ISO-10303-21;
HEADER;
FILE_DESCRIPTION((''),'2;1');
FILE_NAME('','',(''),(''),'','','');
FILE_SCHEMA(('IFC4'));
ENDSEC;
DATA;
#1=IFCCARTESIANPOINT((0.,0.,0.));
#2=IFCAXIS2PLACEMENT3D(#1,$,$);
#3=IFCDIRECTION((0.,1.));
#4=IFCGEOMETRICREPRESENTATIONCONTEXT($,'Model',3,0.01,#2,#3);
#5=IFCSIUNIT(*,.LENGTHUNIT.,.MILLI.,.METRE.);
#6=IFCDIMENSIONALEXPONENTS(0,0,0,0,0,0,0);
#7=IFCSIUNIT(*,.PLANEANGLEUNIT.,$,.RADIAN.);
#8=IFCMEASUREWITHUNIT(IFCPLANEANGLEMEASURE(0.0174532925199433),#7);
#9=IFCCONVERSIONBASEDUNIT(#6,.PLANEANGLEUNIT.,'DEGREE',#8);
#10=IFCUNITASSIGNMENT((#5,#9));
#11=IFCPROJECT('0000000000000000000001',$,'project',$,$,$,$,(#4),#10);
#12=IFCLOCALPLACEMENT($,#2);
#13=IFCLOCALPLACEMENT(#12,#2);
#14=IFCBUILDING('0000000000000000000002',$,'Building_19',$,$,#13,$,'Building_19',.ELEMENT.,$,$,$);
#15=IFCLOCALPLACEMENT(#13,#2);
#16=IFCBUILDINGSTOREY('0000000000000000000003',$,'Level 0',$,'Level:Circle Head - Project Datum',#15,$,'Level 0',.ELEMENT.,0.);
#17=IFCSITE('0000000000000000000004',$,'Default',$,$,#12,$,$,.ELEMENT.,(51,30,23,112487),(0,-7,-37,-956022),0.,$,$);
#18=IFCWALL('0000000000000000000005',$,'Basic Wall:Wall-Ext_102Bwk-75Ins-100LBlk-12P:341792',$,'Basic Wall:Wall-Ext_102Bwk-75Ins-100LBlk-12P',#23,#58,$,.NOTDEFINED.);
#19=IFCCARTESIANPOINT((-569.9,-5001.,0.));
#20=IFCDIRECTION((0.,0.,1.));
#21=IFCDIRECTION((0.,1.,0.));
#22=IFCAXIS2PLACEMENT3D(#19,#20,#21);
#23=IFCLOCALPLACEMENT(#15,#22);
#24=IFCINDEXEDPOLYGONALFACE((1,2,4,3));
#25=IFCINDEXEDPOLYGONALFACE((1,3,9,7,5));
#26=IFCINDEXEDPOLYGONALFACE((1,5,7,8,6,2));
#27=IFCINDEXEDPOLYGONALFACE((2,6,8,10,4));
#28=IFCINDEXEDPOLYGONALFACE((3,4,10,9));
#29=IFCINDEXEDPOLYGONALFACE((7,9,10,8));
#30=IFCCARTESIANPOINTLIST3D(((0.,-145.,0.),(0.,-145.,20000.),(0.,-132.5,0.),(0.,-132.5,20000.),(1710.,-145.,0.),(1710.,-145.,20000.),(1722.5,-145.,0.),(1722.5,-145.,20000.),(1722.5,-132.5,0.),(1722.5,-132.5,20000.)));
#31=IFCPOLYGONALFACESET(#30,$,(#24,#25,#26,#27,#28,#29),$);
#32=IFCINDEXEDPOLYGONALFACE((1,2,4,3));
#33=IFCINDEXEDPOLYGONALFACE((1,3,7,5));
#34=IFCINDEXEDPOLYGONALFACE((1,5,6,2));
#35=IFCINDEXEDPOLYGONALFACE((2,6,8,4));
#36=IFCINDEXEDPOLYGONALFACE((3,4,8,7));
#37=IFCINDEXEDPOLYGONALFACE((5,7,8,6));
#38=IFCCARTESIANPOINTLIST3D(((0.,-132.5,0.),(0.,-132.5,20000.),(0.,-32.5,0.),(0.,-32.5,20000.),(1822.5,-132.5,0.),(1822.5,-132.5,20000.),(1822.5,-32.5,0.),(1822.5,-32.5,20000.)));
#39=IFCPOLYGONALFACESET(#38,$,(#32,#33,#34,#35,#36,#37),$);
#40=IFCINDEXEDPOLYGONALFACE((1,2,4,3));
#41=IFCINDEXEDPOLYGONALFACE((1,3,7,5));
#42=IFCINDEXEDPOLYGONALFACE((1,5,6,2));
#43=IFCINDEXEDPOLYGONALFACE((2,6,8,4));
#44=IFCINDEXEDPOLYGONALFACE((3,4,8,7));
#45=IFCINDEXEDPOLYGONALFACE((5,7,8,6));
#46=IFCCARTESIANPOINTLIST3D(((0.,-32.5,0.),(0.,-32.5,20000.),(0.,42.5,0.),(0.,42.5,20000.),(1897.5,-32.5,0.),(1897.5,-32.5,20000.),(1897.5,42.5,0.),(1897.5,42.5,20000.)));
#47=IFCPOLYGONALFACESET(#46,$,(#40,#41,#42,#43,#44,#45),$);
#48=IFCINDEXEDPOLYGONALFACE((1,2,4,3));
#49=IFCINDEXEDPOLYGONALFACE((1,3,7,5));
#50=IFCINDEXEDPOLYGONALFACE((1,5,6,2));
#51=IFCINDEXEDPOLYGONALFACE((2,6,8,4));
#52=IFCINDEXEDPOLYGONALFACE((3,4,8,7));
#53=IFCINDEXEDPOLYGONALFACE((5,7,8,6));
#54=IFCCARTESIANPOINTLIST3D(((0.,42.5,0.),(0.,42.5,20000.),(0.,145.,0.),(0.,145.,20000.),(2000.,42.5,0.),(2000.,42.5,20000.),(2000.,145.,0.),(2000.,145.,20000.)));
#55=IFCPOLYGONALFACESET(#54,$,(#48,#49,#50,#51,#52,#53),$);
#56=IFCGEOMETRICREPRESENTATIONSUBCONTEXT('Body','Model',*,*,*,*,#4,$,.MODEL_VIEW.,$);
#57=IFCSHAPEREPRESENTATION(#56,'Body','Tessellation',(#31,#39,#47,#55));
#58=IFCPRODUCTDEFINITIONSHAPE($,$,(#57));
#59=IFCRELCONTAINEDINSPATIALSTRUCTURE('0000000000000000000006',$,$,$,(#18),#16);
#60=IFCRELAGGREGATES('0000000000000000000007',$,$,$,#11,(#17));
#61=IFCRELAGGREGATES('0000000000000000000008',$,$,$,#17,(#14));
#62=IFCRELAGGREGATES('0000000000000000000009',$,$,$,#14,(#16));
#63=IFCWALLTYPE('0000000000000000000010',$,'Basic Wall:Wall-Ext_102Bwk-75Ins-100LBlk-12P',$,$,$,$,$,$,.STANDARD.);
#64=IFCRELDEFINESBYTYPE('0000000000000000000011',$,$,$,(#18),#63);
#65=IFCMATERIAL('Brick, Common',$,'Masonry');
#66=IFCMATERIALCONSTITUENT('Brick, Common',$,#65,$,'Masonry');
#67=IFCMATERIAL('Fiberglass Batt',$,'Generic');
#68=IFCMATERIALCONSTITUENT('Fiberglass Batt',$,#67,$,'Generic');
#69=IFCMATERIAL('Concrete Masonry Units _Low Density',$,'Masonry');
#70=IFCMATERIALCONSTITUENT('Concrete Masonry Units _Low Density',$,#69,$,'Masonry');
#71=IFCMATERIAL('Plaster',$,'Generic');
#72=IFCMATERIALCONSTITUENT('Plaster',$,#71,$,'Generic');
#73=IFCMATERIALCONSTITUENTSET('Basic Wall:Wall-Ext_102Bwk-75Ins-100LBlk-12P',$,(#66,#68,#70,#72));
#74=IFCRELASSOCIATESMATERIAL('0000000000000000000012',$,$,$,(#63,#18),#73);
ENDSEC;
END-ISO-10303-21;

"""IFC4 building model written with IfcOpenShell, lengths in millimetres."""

from ifc_helpers import new_model, entity, si_unit, converted_unit, direction, frame, origin, place, context, subcontext, project, spatial, indexed_curve, outline, extrude, material, constituent, constituent_set, type_object, element, save


model = new_model("IFC4")

# Units and contexts
model_context = context("Model", 3, precision=0.01, world=origin(), true_north=direction((0.0, 1.0)))
body_context = subcontext(model_context, "Body", "Model", "MODEL_VIEW")
ifc_project = project(units=[si_unit("LENGTHUNIT", "METRE", prefix="MILLI"), converted_unit("PLANEANGLEUNIT", "DEGREE", entity("IfcPlaneAngleMeasure", 0.0174532925199433), si_unit("PLANEANGLEUNIT", "RADIAN"), dimensions=[0, 0, 0, 0, 0, 0, 0])], contexts=[model_context])

# Site, building, storey
site_placement = place(None, origin())
site = spatial("IfcSite", under=ifc_project, at=site_placement, Name="Default", CompositionType="ELEMENT", RefLatitude=(51, 30, 23, 112487), RefLongitude=(0, -7, -37, -956022), RefElevation=0.0)
building_placement = place(site_placement, origin())
building = spatial("IfcBuilding", under=site, at=building_placement, Name="Building_19", LongName="Building_19", CompositionType="ELEMENT")
storey_placement = place(building_placement, origin())
storey = spatial("IfcBuildingStorey", under=building, at=storey_placement, Name="Level 0", ObjectType="Level:Circle Head - Project Datum", LongName="Level 0", CompositionType="ELEMENT", Elevation=0.0)

# Shared definitions
ifc_material_1 = material(Name="Brick, Common", Category="Masonry")
ifc_constituent_1 = constituent(ifc_material_1, Name="Brick, Common", Category="Masonry")
ifc_material_2 = material(Name="Fiberglass Batt", Category="Generic")
ifc_constituent_2 = constituent(ifc_material_2, Name="Fiberglass Batt", Category="Generic")
ifc_material_3 = material(Name="Concrete Masonry Units _Low Density", Category="Masonry")
ifc_constituent_3 = constituent(ifc_material_3, Name="Concrete Masonry Units _Low Density", Category="Masonry")
ifc_material_4 = material(Name="Plaster", Category="Generic")
ifc_constituent_4 = constituent(ifc_material_4, Name="Plaster", Category="Generic")
ifc_constituent_set_1 = constituent_set(constituents=[ifc_constituent_1, ifc_constituent_2, ifc_constituent_3, ifc_constituent_4], Name="Basic Wall:Wall-Ext_102Bwk-75Ins-100LBlk-12P")
wall_type_1 = type_object("IfcWallType", Name="Basic Wall:Wall-Ext_102Bwk-75Ins-100LBlk-12P", PredefinedType="STANDARD", material=ifc_constituent_set_1)

# Wall
wall_1_placement = place(storey_placement, frame((-569.9, -5001.0, 0.0), z_axis=(0.0, 0.0, 1.0), x_axis=(0.0, 1.0, 0.0)))
element("IfcWall", 1, at=wall_1_placement, inside=storey, type_object=wall_type_1, material=ifc_constituent_set_1, Name="Basic Wall:Wall-Ext_102Bwk-75Ins-100LBlk-12P:341792", ObjectType="Basic Wall:Wall-Ext_102Bwk-75Ins-100LBlk-12P", PredefinedType="NOTDEFINED", context=body_context, shape_type="SweptSolid", body=[
    extrude(outline(indexed_curve([(679.0, -5.0), (691.5, -5.0), (691.5, 7.5), (-1031.0, 7.5), (-1031.0, -5.0), (679.0, -5.0)], self_intersect=False)), frame((1031.0, -140.0, 0.0)), (0.0, 0.0, 1.0), 20000.0),
    extrude(outline(indexed_curve([(-911.2, -50.0), (911.2, -50.0), (911.2, 50.0), (-911.2, 50.0), (-911.2, -50.0)], self_intersect=False)), frame((911.3, -82.5, 0.0)), (0.0, 0.0, 1.0), 20000.0),
    extrude(outline(indexed_curve([(-948.8, -37.5), (948.8, -37.5), (948.8, 37.5), (-948.7, 37.5), (-948.8, -37.5)], self_intersect=False)), frame((948.8, 5.0, 0.0)), (0.0, 0.0, 1.0), 20000.0),
    extrude(outline(indexed_curve([(-51.3, -1000.0), (51.2, -1000.0), (51.3, 1000.0), (-51.2, 1000.0), (-51.3, -1000.0)], self_intersect=False)), frame((1000.0, 93.8, 0.0), z_axis=(0.0, 0.0, 1.0), x_axis=(0.0, -1.0, 0.0)), (0.0, 0.0, 1.0), 20000.0),
])

save(model, "model.ifc")
